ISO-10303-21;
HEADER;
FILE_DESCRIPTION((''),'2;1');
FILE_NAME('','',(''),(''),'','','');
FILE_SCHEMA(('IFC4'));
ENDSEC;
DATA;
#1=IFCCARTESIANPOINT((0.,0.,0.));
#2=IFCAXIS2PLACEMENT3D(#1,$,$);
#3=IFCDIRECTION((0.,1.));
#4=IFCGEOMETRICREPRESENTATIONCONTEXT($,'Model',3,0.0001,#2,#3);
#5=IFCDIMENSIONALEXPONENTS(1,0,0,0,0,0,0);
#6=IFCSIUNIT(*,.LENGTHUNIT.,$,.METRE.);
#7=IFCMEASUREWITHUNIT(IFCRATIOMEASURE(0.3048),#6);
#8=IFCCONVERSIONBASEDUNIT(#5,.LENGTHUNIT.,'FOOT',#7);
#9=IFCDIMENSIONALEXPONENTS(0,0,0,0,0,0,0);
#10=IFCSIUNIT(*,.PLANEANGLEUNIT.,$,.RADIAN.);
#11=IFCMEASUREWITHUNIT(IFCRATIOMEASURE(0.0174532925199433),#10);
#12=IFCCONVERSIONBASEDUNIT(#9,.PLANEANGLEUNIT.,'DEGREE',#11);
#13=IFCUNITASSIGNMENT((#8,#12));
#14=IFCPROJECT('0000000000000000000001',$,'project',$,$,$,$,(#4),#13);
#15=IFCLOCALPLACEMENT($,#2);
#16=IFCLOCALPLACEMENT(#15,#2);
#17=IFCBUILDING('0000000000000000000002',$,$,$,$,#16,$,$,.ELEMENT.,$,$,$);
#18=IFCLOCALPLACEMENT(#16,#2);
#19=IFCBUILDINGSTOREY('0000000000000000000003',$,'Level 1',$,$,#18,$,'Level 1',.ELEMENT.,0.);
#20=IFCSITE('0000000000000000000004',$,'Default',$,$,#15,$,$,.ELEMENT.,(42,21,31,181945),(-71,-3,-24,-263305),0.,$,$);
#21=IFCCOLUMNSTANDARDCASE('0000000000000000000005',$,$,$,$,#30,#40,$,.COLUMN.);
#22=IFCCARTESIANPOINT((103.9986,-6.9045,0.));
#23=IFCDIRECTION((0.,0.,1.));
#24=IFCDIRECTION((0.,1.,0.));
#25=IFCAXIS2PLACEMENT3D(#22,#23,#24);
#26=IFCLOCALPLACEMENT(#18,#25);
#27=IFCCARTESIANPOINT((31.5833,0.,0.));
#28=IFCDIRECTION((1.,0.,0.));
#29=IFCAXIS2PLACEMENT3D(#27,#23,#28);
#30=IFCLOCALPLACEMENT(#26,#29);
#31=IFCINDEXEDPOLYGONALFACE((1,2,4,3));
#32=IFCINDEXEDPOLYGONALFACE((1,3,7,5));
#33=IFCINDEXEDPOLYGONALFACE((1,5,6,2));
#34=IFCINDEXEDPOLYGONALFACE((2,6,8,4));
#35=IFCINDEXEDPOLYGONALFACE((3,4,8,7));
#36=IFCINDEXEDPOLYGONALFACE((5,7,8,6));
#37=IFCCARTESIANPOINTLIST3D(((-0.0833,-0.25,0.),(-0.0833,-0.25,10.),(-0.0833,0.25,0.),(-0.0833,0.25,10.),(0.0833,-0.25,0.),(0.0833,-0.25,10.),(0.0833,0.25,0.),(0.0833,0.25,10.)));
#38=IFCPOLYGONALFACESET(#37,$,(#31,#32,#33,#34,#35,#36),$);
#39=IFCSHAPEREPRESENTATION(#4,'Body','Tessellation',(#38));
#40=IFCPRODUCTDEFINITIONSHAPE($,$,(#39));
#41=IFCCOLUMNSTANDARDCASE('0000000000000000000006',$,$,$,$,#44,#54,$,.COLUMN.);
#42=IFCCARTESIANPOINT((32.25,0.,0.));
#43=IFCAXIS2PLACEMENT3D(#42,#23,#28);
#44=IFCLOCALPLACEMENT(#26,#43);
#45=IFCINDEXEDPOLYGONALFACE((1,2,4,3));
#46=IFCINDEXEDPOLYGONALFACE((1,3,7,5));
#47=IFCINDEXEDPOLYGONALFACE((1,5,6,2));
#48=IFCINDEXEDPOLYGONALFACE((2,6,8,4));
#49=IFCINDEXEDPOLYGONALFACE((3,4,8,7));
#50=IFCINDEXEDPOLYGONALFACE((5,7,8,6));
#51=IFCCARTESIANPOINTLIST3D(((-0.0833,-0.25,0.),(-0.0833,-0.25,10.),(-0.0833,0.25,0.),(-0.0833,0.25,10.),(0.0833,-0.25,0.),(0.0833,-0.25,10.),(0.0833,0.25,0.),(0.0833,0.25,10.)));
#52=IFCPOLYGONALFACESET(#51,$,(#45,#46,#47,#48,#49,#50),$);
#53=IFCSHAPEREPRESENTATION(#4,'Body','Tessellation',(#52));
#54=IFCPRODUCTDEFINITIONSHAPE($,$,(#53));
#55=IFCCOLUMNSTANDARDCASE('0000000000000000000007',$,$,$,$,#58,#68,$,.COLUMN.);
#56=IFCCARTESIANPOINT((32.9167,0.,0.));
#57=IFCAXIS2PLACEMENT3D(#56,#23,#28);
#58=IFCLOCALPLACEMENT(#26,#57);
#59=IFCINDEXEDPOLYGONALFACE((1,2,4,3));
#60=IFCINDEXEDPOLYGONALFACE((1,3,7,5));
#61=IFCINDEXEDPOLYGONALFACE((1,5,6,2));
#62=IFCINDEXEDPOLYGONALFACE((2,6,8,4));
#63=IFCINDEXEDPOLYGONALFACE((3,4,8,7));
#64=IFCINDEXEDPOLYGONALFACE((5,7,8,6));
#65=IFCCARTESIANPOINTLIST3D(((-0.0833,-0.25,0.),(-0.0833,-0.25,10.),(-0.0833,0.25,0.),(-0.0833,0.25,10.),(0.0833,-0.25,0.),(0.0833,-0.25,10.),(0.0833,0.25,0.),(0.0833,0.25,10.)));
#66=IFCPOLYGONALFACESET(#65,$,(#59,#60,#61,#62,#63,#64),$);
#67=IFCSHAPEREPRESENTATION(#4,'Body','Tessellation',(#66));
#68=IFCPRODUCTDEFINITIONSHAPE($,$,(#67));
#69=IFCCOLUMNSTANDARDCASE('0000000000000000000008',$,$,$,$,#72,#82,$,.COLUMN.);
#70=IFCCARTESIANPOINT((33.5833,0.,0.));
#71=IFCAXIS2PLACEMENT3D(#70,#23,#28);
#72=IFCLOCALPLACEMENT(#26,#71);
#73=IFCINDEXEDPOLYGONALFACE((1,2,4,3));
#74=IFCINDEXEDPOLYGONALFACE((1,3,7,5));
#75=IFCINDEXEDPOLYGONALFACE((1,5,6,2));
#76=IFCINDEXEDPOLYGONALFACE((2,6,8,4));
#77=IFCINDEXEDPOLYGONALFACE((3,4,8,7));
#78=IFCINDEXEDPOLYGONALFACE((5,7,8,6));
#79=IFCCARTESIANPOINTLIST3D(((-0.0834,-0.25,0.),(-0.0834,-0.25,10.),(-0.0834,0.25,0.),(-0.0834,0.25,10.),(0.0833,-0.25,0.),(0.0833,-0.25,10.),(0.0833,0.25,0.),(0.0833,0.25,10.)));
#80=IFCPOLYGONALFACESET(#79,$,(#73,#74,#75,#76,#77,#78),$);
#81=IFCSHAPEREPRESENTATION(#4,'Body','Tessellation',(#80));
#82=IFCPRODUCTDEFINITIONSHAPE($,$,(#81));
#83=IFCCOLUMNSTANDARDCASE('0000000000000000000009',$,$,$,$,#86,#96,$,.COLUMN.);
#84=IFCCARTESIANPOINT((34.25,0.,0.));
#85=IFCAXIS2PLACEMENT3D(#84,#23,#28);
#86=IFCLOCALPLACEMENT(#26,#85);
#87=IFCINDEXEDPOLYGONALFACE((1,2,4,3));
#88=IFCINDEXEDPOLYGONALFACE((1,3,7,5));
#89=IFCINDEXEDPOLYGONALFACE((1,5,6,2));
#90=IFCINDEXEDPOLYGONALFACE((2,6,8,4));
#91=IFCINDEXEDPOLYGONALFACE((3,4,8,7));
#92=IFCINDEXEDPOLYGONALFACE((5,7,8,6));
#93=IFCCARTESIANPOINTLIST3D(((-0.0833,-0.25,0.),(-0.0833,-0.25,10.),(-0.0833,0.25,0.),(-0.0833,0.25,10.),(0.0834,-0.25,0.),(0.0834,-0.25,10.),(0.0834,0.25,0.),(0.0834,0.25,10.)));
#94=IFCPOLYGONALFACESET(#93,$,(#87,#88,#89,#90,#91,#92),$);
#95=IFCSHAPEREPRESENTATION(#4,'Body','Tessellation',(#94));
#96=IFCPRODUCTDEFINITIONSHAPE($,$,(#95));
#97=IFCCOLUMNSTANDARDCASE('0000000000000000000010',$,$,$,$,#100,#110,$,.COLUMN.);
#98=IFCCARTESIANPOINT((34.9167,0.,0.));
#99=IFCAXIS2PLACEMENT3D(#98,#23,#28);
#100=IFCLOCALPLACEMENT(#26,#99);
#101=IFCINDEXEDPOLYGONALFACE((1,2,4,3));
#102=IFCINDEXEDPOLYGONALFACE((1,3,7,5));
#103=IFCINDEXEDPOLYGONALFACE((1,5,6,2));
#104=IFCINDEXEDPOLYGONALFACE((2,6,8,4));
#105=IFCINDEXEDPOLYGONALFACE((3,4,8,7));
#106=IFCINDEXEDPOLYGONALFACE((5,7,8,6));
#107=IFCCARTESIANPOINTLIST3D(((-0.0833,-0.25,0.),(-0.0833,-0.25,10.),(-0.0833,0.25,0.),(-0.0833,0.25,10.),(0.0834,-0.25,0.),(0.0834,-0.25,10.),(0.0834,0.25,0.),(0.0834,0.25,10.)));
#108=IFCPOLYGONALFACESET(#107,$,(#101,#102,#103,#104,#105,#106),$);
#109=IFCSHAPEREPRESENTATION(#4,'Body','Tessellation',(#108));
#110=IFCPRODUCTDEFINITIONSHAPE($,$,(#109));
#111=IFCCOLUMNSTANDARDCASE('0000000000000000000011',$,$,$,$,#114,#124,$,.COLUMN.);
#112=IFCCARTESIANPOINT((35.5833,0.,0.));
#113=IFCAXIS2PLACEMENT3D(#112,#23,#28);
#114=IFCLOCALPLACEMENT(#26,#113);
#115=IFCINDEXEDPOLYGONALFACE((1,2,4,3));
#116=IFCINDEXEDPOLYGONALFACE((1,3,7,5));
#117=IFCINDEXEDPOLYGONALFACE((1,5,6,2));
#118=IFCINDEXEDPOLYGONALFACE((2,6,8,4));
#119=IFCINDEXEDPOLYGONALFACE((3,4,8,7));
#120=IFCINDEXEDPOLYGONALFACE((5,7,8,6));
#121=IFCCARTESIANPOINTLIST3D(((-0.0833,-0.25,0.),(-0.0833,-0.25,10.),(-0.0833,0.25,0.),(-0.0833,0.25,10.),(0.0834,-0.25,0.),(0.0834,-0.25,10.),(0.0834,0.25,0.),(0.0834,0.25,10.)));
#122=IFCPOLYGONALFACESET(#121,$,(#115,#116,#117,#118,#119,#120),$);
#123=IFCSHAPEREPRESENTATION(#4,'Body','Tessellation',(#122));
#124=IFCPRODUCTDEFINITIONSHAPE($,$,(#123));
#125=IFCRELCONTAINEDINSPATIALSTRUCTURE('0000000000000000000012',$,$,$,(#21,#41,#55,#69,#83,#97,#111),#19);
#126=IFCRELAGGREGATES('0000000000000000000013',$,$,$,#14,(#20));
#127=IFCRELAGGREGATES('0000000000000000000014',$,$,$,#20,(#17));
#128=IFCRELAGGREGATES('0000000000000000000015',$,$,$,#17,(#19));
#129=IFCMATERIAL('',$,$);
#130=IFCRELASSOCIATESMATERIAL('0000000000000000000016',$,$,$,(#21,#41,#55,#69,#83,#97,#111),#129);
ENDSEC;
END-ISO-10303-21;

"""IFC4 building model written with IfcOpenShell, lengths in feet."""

from ifc_helpers import new_model, entity, si_unit, converted_unit, direction, frame, origin, place, context, project, spatial, rectangle, extrude, material, element, save


model = new_model("IFC4")

# Units and contexts
model_context = context("Model", 3, precision=0.0001, world=origin(), true_north=direction((0.0, 1.0)))
ifc_project = project(units=[converted_unit("LENGTHUNIT", "FOOT", entity("IfcRatioMeasure", 0.3048), si_unit("LENGTHUNIT", "METRE"), dimensions=[1, 0, 0, 0, 0, 0, 0]), converted_unit("PLANEANGLEUNIT", "DEGREE", entity("IfcRatioMeasure", 0.0174532925199433), si_unit("PLANEANGLEUNIT", "RADIAN"), dimensions=[0, 0, 0, 0, 0, 0, 0])], contexts=[model_context])

# Site, building, storey
site_placement = place(None, origin())
site = spatial("IfcSite", under=ifc_project, at=site_placement, Name="Default", CompositionType="ELEMENT", RefLatitude=(42, 21, 31, 181945), RefLongitude=(-71, -3, -24, -263305), RefElevation=0.0)
building_placement = place(site_placement, origin())
building = spatial("IfcBuilding", under=site, at=building_placement, CompositionType="ELEMENT")
storey_placement = place(building_placement, origin())
storey = spatial("IfcBuildingStorey", under=building, at=storey_placement, Name="Level 1", LongName="Level 1", CompositionType="ELEMENT", Elevation=0.0)

# Columns
ifc_material_1 = material(Name="")
placement_1 = place(storey_placement, frame((103.9986, -6.9045, 0.0), z_axis=(0.0, 0.0, 1.0), x_axis=(0.0, 1.0, 0.0)))
for number, where, z_axis, x_axis in (
    (1, (31.5833, 0.0, 0.0), (0.0, 0.0, 1.0), (1.0, 0.0, 0.0)),
    (2, (32.25, 0.0, 0.0), (0.0, 0.0, 1.0), (1.0, 0.0, 0.0)),
    (3, (32.9167, 0.0, 0.0), (0.0, 0.0, 1.0), (1.0, 0.0, 0.0)),
    (4, (33.5833, 0.0, 0.0), (0.0, 0.0, 1.0), (1.0, 0.0, 0.0)),
    (5, (34.25, 0.0, 0.0), (0.0, 0.0, 1.0), (1.0, 0.0, 0.0)),
    (6, (34.9167, 0.0, 0.0), (0.0, 0.0, 1.0), (1.0, 0.0, 0.0)),
    (7, (35.5833, 0.0, 0.0), (0.0, 0.0, 1.0), (1.0, 0.0, 0.0)),
):
    element("IfcColumnStandardCase", number, at=place(placement_1, frame(where, z_axis=z_axis, x_axis=x_axis)), inside=storey, material=ifc_material_1, PredefinedType="COLUMN", context=model_context, shape_type="SweptSolid", body=[
        extrude(rectangle(XDim=0.1667, YDim=0.5), origin(), (0.0, 0.0, 1.0), 10.0),
    ])

save(model, "model.ifc")
